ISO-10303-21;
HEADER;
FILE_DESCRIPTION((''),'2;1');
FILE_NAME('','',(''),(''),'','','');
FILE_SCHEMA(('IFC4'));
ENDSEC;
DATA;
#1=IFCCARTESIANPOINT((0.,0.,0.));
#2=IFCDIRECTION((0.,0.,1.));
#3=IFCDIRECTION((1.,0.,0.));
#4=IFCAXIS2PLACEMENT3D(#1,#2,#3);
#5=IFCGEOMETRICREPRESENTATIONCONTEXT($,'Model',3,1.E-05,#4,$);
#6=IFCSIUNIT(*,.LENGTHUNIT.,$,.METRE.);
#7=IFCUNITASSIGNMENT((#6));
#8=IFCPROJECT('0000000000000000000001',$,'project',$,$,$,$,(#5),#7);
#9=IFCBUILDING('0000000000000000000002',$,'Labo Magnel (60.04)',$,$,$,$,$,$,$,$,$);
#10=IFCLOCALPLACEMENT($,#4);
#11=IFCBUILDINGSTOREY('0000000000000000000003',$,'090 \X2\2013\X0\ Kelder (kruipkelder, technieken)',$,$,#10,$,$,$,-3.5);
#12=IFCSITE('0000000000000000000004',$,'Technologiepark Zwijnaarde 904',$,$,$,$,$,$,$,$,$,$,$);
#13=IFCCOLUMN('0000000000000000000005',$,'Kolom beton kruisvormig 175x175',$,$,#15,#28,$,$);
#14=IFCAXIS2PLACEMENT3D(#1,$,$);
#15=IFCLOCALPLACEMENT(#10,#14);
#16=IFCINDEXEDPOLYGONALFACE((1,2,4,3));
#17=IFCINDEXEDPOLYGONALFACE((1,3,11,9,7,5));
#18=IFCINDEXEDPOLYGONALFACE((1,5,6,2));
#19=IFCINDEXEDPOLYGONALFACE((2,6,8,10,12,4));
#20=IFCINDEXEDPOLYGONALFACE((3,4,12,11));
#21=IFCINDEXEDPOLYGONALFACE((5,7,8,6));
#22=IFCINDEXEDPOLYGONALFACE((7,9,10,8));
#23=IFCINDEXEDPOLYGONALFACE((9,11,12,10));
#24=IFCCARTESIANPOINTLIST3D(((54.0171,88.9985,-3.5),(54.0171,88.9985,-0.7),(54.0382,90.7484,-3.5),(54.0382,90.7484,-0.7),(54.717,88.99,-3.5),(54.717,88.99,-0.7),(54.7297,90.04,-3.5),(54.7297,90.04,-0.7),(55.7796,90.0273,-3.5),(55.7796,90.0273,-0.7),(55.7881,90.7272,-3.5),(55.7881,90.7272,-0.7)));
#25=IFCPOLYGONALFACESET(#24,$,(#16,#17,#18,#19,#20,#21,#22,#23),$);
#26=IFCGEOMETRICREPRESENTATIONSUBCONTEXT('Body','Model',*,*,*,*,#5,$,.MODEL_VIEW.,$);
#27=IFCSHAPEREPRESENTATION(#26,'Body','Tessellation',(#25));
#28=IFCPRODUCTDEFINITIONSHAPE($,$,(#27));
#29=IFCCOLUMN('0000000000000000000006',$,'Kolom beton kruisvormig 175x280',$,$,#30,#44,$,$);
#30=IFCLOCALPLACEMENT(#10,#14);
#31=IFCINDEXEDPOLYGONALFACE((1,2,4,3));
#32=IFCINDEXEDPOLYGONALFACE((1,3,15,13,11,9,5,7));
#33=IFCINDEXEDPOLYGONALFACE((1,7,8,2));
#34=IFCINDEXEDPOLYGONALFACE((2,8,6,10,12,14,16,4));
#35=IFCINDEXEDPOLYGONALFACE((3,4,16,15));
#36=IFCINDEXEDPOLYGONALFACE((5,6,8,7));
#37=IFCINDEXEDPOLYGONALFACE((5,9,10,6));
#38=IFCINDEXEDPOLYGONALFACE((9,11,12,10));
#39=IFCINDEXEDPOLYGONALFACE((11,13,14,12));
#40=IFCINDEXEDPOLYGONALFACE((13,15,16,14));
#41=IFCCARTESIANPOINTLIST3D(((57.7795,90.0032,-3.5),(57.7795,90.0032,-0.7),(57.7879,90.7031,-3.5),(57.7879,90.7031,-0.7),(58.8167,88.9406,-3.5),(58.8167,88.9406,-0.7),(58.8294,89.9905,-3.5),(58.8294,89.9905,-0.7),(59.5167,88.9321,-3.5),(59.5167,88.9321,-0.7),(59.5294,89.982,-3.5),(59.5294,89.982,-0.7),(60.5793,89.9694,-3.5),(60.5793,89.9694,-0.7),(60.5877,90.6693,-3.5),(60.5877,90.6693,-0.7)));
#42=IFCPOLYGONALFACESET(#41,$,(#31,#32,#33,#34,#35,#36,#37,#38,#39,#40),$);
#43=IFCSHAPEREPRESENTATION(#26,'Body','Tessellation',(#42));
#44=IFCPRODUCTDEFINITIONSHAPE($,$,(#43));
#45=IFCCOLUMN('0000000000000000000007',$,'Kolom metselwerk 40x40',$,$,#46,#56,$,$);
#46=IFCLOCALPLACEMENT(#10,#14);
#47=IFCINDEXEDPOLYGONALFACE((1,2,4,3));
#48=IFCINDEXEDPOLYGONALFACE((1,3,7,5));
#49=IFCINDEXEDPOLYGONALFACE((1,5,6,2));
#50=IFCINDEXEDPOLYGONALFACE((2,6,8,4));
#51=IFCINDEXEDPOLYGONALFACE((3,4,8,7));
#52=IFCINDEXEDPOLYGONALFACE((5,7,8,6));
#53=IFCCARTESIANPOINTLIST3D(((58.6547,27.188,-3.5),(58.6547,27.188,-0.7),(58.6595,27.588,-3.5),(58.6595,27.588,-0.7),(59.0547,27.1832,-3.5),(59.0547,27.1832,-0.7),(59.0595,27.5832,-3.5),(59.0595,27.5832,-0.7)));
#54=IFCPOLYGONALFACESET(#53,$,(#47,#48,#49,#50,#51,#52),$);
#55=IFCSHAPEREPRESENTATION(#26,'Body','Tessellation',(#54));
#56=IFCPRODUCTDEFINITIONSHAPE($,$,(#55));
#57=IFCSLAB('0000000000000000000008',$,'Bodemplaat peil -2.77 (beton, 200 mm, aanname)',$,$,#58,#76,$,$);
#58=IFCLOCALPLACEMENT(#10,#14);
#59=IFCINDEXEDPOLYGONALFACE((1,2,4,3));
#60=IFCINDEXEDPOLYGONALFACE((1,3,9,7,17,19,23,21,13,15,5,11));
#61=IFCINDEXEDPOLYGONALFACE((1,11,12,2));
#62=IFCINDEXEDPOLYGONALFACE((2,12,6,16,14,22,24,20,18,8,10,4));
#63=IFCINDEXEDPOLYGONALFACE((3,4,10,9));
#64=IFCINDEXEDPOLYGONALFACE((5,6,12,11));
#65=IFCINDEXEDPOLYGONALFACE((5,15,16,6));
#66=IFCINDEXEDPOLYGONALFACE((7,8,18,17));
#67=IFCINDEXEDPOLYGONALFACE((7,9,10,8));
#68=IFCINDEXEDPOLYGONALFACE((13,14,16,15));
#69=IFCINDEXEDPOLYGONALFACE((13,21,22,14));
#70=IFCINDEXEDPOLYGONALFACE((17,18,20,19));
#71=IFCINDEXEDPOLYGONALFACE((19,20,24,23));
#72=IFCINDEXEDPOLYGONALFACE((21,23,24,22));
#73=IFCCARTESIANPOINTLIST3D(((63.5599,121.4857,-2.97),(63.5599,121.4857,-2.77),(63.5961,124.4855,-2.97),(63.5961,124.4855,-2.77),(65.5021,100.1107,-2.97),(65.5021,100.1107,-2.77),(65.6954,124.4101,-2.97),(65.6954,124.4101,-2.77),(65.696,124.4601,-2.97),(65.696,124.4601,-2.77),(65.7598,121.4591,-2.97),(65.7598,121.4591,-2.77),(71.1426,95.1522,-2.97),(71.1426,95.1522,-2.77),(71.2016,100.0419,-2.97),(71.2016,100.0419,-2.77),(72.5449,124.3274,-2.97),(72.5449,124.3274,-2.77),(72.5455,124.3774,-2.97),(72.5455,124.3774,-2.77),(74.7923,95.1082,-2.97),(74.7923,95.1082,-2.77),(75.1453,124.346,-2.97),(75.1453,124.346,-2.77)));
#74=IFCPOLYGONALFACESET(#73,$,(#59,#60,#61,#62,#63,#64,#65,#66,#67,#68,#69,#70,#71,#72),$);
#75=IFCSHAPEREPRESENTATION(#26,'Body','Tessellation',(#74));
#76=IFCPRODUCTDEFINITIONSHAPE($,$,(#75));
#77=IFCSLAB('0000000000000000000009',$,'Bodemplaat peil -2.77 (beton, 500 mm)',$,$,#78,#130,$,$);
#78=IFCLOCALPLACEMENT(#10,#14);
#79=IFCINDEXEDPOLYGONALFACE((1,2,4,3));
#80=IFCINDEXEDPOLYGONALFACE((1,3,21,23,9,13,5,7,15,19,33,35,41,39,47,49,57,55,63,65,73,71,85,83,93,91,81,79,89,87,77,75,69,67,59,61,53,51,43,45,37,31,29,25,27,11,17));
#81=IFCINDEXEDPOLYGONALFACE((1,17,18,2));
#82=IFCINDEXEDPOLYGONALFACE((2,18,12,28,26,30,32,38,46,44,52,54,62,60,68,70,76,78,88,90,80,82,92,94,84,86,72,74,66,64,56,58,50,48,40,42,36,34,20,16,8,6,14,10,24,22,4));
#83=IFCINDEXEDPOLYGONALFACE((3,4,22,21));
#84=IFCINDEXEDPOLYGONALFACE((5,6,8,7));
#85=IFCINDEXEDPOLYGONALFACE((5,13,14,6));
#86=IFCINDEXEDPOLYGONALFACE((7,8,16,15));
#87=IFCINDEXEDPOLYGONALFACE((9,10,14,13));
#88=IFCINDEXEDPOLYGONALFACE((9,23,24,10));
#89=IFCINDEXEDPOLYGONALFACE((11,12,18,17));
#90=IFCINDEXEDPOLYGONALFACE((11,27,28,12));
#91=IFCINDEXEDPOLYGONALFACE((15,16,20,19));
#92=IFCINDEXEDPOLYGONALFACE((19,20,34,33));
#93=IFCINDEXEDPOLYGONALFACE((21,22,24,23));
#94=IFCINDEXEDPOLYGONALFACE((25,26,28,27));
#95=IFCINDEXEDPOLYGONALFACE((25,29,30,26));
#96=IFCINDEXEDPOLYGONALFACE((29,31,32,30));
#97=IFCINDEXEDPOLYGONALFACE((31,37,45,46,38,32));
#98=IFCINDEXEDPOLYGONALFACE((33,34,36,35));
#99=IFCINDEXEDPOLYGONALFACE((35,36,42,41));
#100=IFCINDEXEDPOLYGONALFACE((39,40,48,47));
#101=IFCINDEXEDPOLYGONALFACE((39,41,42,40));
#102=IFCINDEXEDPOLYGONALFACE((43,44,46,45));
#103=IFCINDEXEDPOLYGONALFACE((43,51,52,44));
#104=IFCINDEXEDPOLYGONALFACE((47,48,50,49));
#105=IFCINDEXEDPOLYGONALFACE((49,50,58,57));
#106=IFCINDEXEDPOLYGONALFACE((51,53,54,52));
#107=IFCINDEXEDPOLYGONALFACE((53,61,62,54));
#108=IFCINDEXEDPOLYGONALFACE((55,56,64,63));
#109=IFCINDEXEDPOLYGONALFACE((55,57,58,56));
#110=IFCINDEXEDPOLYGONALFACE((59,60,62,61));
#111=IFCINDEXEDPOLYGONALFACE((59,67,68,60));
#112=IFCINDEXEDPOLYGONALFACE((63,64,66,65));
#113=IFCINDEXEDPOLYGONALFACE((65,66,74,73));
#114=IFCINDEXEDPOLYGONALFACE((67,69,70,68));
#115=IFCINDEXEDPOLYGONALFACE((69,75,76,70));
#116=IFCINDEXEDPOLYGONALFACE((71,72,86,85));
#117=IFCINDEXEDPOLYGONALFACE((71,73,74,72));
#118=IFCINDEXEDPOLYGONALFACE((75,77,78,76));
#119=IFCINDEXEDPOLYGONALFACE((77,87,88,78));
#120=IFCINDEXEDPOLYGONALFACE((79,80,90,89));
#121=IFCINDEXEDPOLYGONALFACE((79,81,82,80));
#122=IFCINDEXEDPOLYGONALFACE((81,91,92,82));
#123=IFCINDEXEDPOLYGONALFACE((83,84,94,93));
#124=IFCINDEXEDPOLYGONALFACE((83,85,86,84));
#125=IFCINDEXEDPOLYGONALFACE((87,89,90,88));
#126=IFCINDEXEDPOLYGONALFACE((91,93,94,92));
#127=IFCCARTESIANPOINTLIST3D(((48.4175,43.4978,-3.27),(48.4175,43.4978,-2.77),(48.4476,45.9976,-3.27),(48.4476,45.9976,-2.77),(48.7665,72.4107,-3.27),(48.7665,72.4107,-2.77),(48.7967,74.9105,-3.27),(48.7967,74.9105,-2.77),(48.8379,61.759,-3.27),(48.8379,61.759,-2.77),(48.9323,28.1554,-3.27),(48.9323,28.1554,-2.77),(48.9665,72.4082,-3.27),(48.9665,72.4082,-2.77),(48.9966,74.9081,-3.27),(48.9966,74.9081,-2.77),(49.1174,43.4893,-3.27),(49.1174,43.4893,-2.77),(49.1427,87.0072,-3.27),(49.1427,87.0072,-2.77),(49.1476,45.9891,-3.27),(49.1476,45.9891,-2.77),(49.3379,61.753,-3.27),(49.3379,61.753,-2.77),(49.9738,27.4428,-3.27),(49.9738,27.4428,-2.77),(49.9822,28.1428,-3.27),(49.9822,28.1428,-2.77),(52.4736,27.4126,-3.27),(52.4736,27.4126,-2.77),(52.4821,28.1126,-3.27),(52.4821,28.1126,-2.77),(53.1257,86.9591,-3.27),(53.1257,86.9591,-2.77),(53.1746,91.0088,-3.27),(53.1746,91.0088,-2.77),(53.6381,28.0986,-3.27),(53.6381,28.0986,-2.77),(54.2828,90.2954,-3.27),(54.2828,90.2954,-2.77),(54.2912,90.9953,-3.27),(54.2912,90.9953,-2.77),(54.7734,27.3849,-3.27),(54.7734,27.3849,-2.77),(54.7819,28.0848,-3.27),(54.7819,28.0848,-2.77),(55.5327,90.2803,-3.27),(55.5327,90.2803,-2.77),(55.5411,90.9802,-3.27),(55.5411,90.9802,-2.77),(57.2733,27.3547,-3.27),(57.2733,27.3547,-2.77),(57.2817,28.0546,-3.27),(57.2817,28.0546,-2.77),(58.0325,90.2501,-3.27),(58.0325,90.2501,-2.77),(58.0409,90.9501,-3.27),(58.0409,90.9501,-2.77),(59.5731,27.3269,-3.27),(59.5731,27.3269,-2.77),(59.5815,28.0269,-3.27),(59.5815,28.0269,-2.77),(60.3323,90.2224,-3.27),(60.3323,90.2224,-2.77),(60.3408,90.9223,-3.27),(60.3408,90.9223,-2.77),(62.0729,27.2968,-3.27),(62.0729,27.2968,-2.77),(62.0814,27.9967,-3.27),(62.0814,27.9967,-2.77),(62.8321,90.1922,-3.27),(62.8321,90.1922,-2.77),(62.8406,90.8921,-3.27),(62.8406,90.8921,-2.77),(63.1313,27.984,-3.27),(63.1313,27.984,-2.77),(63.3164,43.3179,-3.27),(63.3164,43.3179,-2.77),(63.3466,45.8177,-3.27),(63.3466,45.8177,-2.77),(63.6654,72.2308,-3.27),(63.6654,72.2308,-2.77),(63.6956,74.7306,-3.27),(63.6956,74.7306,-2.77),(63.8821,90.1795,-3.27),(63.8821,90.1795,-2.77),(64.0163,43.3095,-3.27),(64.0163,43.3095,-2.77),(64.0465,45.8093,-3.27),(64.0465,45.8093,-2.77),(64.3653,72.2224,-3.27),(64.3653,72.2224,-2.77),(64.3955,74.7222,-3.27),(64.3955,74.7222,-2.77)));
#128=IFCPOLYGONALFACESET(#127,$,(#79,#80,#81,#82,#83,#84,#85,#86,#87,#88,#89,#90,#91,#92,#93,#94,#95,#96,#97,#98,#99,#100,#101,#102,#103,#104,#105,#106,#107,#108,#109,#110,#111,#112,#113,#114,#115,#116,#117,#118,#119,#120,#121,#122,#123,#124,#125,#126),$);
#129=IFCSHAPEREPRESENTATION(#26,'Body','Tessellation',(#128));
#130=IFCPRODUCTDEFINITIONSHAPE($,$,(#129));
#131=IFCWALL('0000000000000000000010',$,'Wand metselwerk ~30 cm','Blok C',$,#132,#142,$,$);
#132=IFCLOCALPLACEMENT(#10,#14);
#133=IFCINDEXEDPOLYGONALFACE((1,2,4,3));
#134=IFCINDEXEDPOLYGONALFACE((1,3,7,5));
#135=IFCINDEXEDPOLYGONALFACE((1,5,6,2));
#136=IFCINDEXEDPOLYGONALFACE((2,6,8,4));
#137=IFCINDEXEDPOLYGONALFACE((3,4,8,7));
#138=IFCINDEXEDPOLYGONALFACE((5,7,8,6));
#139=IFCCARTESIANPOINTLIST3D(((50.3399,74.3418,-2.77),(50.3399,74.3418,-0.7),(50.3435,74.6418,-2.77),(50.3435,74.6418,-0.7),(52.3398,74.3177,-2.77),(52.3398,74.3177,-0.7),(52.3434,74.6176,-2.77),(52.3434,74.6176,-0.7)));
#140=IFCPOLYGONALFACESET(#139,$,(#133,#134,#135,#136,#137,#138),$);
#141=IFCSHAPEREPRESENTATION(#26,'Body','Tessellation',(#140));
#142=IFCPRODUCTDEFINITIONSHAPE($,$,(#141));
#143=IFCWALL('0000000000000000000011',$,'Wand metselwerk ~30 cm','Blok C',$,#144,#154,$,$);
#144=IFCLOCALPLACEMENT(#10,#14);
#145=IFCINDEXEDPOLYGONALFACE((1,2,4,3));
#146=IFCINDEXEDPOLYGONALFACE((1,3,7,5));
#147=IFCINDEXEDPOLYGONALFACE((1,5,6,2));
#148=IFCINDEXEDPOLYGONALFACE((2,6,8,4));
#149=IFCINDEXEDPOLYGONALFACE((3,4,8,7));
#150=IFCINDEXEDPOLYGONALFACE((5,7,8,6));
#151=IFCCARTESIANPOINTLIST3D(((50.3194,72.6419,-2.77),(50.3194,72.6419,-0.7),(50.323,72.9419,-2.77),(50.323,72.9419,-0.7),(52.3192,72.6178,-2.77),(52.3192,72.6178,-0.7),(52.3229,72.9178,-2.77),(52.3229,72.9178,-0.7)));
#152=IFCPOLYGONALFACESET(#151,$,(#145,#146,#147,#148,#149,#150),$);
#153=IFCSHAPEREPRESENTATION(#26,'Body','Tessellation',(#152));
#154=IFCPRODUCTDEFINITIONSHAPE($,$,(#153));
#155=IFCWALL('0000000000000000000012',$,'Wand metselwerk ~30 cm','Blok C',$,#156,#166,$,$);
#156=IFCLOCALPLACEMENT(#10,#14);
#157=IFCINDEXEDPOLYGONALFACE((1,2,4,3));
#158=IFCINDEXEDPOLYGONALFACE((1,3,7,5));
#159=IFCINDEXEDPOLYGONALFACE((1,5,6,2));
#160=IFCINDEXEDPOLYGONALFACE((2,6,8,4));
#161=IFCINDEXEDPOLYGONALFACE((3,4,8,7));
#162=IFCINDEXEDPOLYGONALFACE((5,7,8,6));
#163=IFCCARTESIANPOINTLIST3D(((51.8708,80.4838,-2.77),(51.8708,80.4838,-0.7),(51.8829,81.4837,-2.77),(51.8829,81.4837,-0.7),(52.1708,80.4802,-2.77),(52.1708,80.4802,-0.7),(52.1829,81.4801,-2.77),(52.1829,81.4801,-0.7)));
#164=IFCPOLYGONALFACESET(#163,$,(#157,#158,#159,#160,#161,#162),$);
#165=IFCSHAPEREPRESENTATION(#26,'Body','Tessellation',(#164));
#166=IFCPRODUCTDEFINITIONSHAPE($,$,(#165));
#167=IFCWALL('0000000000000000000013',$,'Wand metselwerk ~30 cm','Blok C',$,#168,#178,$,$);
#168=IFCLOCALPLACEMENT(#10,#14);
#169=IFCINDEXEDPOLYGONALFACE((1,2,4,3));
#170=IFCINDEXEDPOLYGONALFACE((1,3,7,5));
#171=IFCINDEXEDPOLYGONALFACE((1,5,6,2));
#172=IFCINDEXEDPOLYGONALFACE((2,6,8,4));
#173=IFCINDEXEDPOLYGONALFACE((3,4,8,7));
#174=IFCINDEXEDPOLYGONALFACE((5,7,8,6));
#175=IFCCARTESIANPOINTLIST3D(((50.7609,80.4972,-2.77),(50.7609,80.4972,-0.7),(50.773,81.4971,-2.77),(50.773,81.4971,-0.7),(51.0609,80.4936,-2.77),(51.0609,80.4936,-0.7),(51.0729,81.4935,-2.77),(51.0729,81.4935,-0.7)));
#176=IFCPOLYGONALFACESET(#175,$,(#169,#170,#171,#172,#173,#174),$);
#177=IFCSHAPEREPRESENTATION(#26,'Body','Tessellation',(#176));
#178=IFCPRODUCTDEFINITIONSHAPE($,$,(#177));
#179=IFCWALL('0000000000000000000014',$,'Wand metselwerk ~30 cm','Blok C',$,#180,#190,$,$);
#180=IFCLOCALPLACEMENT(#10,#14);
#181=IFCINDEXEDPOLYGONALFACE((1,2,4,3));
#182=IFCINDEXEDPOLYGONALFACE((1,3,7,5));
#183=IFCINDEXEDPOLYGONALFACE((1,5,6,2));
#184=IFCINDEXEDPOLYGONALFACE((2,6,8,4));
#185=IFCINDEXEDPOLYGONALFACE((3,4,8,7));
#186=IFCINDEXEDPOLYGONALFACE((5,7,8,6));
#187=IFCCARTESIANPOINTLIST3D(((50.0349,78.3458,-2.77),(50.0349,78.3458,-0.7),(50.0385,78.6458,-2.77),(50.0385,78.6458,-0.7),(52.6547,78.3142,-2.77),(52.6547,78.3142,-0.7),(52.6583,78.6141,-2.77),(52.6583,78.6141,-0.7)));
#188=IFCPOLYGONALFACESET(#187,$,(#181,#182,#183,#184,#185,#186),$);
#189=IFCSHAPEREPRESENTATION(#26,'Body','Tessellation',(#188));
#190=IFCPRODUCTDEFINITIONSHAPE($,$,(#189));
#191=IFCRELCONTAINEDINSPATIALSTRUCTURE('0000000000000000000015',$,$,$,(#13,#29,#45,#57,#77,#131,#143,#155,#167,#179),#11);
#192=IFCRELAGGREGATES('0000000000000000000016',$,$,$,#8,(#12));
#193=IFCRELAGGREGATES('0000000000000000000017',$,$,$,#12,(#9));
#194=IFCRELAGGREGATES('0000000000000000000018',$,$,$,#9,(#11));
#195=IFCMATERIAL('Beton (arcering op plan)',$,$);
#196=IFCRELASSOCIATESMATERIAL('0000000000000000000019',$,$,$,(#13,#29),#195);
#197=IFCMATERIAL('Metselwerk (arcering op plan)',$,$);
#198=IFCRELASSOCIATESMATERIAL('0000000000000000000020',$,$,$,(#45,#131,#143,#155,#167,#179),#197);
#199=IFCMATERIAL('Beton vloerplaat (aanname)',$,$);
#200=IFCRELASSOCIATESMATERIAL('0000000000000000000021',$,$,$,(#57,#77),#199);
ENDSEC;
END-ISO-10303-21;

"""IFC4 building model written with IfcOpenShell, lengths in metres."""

from ifc_helpers import new_model, si_unit, frame, origin, origin_with_axes, place, context, subcontext, project, spatial, polyline, outline, extrude, material, element, save


model = new_model("IFC4")

# Units and contexts
model_context = context("Model", 3, precision=1e-05, world=origin_with_axes())
body_context = subcontext(model_context, "Body", "Model", "MODEL_VIEW")
ifc_project = project(units=[si_unit("LENGTHUNIT", "METRE")], contexts=[model_context])

# Site, building, storey
site = spatial("IfcSite", under=ifc_project, Name="Technologiepark Zwijnaarde 904")
building = spatial("IfcBuilding", under=site, Name="Labo Magnel (60.04)")
storey_placement = place(None, origin_with_axes())
storey = spatial("IfcBuildingStorey", under=building, at=storey_placement, Name="090 – Kelder (kruipkelder, technieken)", Elevation=-3.5)

# Shared definitions
ifc_material_1 = material(Name="Beton (arcering op plan)")

# Columns
column_1_placement = place(storey_placement, frame((0.0, 0.0, -3.5), z_axis=(0.0, 0.0, 1.0), x_axis=(1.0, 0.0, 0.0)))
element("IfcColumn", 1, at=column_1_placement, inside=storey, material=ifc_material_1, Name="Kolom beton kruisvormig 175x175", context=body_context, shape_type="SweptSolid", body=[
    extrude(outline(polyline([(55.7881, 90.7272), (54.0382, 90.7484), (54.0171, 88.9985), (54.717, 88.99), (54.7297, 90.04), (55.7796, 90.0273), (55.7881, 90.7272)])), origin(), (0.0, 0.0, 1.0), 2.8),
])
column_2_placement = place(storey_placement, frame((0.0, 0.0, -3.5), z_axis=(0.0, 0.0, 1.0), x_axis=(1.0, 0.0, 0.0)))
element("IfcColumn", 2, at=column_2_placement, inside=storey, material=ifc_material_1, Name="Kolom beton kruisvormig 175x280", context=body_context, shape_type="SweptSolid", body=[
    extrude(outline(polyline([(60.5877, 90.6693), (57.7879, 90.7031), (57.7795, 90.0032), (58.8294, 89.9905), (58.8167, 88.9406), (59.5167, 88.9321), (59.5294, 89.982), (60.5793, 89.9694), (60.5877, 90.6693)])), origin(), (0.0, 0.0, 1.0), 2.8),
])
ifc_material_2 = material(Name="Metselwerk (arcering op plan)")
column_3_placement = place(storey_placement, frame((0.0, 0.0, -3.5), z_axis=(0.0, 0.0, 1.0), x_axis=(1.0, 0.0, 0.0)))
element("IfcColumn", 3, at=column_3_placement, inside=storey, material=ifc_material_2, Name="Kolom metselwerk 40x40", context=body_context, shape_type="SweptSolid", body=[
    extrude(outline(polyline([(59.0595, 27.5832), (58.6595, 27.588), (58.6547, 27.188), (59.0547, 27.1832), (59.0595, 27.5832)])), origin(), (0.0, 0.0, 1.0), 2.8),
])

# Slabs
ifc_material_3 = material(Name="Beton vloerplaat (aanname)")
slab_1_placement = place(storey_placement, frame((0.0, 0.0, -2.97), z_axis=(0.0, 0.0, 1.0), x_axis=(1.0, 0.0, 0.0)))
element("IfcSlab", 4, at=slab_1_placement, inside=storey, material=ifc_material_3, Name="Bodemplaat peil -2.77 (beton, 200 mm, aanname)", context=body_context, shape_type="SweptSolid", body=[
    extrude(outline(polyline([(65.6954, 124.4101), (72.5449, 124.3274), (72.5455, 124.3774), (75.1453, 124.346), (74.7923, 95.1082), (71.1426, 95.1522), (71.2016, 100.0419), (65.5021, 100.1107), (65.7598, 121.4591), (63.5599, 121.4857), (63.5961, 124.4855), (65.696, 124.4601), (65.6954, 124.4101)])), origin(), (0.0, 0.0, 1.0), 0.2),
])
slab_2_placement = place(storey_placement, frame((0.0, 0.0, -3.27), z_axis=(0.0, 0.0, 1.0), x_axis=(1.0, 0.0, 0.0)))
element("IfcSlab", 5, at=slab_2_placement, inside=storey, material=ifc_material_3, Name="Bodemplaat peil -2.77 (beton, 500 mm)", context=body_context, shape_type="SweptSolid", body=[
    extrude(outline(polyline([(48.7665, 72.4107), (48.7967, 74.9105), (48.9966, 74.9081), (49.1427, 87.0072), (53.1257, 86.9591), (53.1746, 91.0088), (54.2912, 90.9953), (54.2828, 90.2954), (55.5327, 90.2803), (55.5411, 90.9802), (58.0409, 90.9501), (58.0325, 90.2501), (60.3323, 90.2224), (60.3408, 90.9223), (62.8406, 90.8921), (62.8321, 90.1922), (63.8821, 90.1795), (63.6956, 74.7306), (64.3955, 74.7222), (64.3653, 72.2224), (63.6654, 72.2308), (63.3466, 45.8177), (64.0465, 45.8093), (64.0163, 43.3095), (63.3164, 43.3179), (63.1313, 27.984), (62.0814, 27.9967), (62.0729, 27.2968), (59.5731, 27.3269), (59.5815, 28.0269), (57.2817, 28.0546), (57.2733, 27.3547), (54.7734, 27.3849), (54.7819, 28.0848), (53.6381, 28.0986), (52.4821, 28.1126), (52.4736, 27.4126), (49.9738, 27.4428), (49.9822, 28.1428), (48.9323, 28.1554), (49.1174, 43.4893), (48.4175, 43.4978), (48.4476, 45.9976), (49.1476, 45.9891), (49.3379, 61.753), (48.8379, 61.759), (48.9665, 72.4082), (48.7665, 72.4107)])), origin(), (0.0, 0.0, 1.0), 0.5),
])

# Walls
wall_1_placement = place(storey_placement, frame((0.0, 0.0, -2.77), z_axis=(0.0, 0.0, 1.0), x_axis=(1.0, 0.0, 0.0)))
element("IfcWall", 6, at=wall_1_placement, inside=storey, material=ifc_material_2, Name="Wand metselwerk ~30 cm", Description="Blok C", context=body_context, shape_type="SweptSolid", body=[
    extrude(outline(polyline([(52.3434, 74.6176), (50.3435, 74.6418), (50.3399, 74.3418), (52.3398, 74.3177), (52.3434, 74.6176)])), origin(), (0.0, 0.0, 1.0), 2.07),
])
wall_2_placement = place(storey_placement, frame((0.0, 0.0, -2.77), z_axis=(0.0, 0.0, 1.0), x_axis=(1.0, 0.0, 0.0)))
element("IfcWall", 7, at=wall_2_placement, inside=storey, material=ifc_material_2, Name="Wand metselwerk ~30 cm", Description="Blok C", context=body_context, shape_type="SweptSolid", body=[
    extrude(outline(polyline([(52.3229, 72.9178), (50.323, 72.9419), (50.3194, 72.6419), (52.3192, 72.6178), (52.3229, 72.9178)])), origin(), (0.0, 0.0, 1.0), 2.07),
])
wall_3_placement = place(storey_placement, frame((0.0, 0.0, -2.77), z_axis=(0.0, 0.0, 1.0), x_axis=(1.0, 0.0, 0.0)))
element("IfcWall", 8, at=wall_3_placement, inside=storey, material=ifc_material_2, Name="Wand metselwerk ~30 cm", Description="Blok C", context=body_context, shape_type="SweptSolid", body=[
    extrude(outline(polyline([(52.1829, 81.4801), (51.8829, 81.4837), (51.8708, 80.4838), (52.1708, 80.4802), (52.1829, 81.4801)])), origin(), (0.0, 0.0, 1.0), 2.07),
])
wall_4_placement = place(storey_placement, frame((0.0, 0.0, -2.77), z_axis=(0.0, 0.0, 1.0), x_axis=(1.0, 0.0, 0.0)))
element("IfcWall", 9, at=wall_4_placement, inside=storey, material=ifc_material_2, Name="Wand metselwerk ~30 cm", Description="Blok C", context=body_context, shape_type="SweptSolid", body=[
    extrude(outline(polyline([(51.0729, 81.4935), (50.773, 81.4971), (50.7609, 80.4972), (51.0609, 80.4936), (51.0729, 81.4935)])), origin(), (0.0, 0.0, 1.0), 2.07),
])
wall_5_placement = place(storey_placement, frame((0.0, 0.0, -2.77), z_axis=(0.0, 0.0, 1.0), x_axis=(1.0, 0.0, 0.0)))
element("IfcWall", 10, at=wall_5_placement, inside=storey, material=ifc_material_2, Name="Wand metselwerk ~30 cm", Description="Blok C", context=body_context, shape_type="SweptSolid", body=[
    extrude(outline(polyline([(52.6583, 78.6141), (50.0385, 78.6458), (50.0349, 78.3458), (52.6547, 78.3142), (52.6583, 78.6141)])), origin(), (0.0, 0.0, 1.0), 2.07),
])

save(model, "model.ifc")
